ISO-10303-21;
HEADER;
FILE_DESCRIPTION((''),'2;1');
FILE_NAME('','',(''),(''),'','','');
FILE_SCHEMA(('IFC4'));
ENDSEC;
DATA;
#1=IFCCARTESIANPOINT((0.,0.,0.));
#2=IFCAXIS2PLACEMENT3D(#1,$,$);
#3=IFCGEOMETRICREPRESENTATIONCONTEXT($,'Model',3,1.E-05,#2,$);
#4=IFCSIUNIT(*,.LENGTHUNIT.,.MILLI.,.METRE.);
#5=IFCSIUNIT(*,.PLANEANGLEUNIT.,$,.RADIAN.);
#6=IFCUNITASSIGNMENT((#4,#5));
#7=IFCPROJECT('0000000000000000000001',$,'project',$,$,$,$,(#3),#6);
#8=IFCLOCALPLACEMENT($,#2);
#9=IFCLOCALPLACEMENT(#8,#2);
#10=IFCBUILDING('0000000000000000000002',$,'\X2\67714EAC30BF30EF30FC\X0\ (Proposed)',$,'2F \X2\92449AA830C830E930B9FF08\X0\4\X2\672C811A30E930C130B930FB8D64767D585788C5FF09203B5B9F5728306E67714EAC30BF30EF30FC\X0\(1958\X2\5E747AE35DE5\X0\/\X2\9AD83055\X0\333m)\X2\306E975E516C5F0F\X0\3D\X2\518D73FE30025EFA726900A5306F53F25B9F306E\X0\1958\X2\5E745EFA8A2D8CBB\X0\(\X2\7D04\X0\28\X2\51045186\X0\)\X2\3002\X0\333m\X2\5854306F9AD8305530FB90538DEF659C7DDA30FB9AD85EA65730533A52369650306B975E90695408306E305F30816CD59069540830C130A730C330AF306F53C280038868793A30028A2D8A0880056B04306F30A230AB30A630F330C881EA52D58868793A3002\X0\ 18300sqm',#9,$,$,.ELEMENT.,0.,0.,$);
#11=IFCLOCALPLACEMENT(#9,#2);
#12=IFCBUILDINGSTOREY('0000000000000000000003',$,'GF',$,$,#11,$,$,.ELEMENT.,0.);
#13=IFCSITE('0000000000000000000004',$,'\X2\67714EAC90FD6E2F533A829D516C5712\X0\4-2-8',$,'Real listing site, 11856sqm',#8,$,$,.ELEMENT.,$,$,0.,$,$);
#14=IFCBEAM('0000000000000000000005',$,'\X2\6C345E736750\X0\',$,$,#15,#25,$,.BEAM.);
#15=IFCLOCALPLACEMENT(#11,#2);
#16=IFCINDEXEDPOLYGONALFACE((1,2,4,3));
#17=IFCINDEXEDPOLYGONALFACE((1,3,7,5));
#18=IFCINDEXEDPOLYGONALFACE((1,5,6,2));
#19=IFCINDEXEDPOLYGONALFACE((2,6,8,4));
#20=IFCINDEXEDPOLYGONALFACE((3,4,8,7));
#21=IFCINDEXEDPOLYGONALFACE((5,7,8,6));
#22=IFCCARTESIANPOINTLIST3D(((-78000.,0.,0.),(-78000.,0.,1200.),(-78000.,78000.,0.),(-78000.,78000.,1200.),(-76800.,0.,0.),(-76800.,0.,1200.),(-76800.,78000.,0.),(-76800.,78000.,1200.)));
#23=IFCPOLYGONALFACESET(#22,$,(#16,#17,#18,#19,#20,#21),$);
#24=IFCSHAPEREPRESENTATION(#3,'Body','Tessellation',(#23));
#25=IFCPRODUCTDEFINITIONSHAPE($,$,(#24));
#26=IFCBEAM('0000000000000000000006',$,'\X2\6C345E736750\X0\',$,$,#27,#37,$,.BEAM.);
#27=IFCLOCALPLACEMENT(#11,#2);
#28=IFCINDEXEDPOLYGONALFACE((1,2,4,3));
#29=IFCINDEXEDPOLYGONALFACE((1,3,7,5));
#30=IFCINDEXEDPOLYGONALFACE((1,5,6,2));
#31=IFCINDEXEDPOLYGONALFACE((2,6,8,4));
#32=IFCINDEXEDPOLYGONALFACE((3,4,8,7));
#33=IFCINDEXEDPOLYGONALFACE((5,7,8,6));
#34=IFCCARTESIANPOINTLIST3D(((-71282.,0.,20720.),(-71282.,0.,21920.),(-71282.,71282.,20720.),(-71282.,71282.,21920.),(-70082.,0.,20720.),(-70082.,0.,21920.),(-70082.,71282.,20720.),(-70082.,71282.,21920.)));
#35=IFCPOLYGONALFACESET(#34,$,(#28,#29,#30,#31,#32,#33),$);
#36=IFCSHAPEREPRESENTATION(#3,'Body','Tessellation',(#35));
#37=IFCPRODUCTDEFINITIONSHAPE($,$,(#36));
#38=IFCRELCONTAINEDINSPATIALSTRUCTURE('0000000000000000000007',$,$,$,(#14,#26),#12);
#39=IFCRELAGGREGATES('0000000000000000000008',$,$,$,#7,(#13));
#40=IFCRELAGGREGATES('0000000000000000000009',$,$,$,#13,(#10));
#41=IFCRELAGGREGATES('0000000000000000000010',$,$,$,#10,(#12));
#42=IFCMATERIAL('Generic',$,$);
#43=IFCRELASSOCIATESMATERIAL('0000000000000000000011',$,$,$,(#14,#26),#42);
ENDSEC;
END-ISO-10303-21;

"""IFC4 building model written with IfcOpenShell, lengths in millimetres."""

from ifc_helpers import new_model, si_unit, frame, frame_2d, origin, place, context, project, spatial, rectangle, extrude, material, element, save


model = new_model("IFC4")

# Units and contexts
model_context = context("Model", 3, precision=1e-05, world=origin())
ifc_project = project(units=[si_unit("LENGTHUNIT", "METRE", prefix="MILLI"), si_unit("PLANEANGLEUNIT", "RADIAN")], contexts=[model_context])

# Site, building, storey
site_placement = place(None, origin())
site = spatial("IfcSite", under=ifc_project, at=site_placement, Name="東京都港区芝公園4-2-8", ObjectType="Real listing site, 11856sqm", CompositionType="ELEMENT", RefElevation=0.0)
building_placement = place(site_placement, origin())
building = spatial("IfcBuilding", under=site, at=building_placement, Name="東京タワー (Proposed)", ObjectType="2F 鉄骨トラス（4本脚ラチス・赤白塗装）※実在の東京タワー(1958年竣工/高さ333m)の非公式3D再現。建物¥は史実の1958年建設費(約28億円)。333m塔は高さ・道路斜線・高度地区制限に非適合のため法適合チェックは参考表示。設計者欄はアカウント自動表示。 18300sqm", CompositionType="ELEMENT", ElevationOfRefHeight=0.0, ElevationOfTerrain=0.0)
storey_placement = place(building_placement, origin())
storey = spatial("IfcBuildingStorey", under=building, at=storey_placement, Name="GF", CompositionType="ELEMENT", Elevation=0.0)

# Shared definitions
ifc_material = material(Name="Generic")

# Beams
beam_1_placement = place(storey_placement, frame((-39000.0, 0.0, 0.0)))
element("IfcBeam", 1, at=beam_1_placement, inside=storey, material=ifc_material, Name="水平材", PredefinedType="BEAM", context=model_context, shape_type="SweptSolid", body=[
    extrude(rectangle(XDim=1200.0, YDim=78000.0, at=frame_2d((600.0, 39000.0))), frame((-39000.0, 0.0, 0.0)), (0.0, 0.0, 1.0), 1200.0),
])
beam_2_placement = place(storey_placement, frame((-35641.0, 0.0, 10360.0)))
element("IfcBeam", 2, at=beam_2_placement, inside=storey, material=ifc_material, Name="水平材", PredefinedType="BEAM", context=model_context, shape_type="SweptSolid", body=[
    extrude(rectangle(XDim=1200.0, YDim=71282.0, at=frame_2d((600.0, 35641.0))), frame((-35641.0, 0.0, 10360.0)), (0.0, 0.0, 1.0), 1200.0),
])

save(model, "model.ifc")
